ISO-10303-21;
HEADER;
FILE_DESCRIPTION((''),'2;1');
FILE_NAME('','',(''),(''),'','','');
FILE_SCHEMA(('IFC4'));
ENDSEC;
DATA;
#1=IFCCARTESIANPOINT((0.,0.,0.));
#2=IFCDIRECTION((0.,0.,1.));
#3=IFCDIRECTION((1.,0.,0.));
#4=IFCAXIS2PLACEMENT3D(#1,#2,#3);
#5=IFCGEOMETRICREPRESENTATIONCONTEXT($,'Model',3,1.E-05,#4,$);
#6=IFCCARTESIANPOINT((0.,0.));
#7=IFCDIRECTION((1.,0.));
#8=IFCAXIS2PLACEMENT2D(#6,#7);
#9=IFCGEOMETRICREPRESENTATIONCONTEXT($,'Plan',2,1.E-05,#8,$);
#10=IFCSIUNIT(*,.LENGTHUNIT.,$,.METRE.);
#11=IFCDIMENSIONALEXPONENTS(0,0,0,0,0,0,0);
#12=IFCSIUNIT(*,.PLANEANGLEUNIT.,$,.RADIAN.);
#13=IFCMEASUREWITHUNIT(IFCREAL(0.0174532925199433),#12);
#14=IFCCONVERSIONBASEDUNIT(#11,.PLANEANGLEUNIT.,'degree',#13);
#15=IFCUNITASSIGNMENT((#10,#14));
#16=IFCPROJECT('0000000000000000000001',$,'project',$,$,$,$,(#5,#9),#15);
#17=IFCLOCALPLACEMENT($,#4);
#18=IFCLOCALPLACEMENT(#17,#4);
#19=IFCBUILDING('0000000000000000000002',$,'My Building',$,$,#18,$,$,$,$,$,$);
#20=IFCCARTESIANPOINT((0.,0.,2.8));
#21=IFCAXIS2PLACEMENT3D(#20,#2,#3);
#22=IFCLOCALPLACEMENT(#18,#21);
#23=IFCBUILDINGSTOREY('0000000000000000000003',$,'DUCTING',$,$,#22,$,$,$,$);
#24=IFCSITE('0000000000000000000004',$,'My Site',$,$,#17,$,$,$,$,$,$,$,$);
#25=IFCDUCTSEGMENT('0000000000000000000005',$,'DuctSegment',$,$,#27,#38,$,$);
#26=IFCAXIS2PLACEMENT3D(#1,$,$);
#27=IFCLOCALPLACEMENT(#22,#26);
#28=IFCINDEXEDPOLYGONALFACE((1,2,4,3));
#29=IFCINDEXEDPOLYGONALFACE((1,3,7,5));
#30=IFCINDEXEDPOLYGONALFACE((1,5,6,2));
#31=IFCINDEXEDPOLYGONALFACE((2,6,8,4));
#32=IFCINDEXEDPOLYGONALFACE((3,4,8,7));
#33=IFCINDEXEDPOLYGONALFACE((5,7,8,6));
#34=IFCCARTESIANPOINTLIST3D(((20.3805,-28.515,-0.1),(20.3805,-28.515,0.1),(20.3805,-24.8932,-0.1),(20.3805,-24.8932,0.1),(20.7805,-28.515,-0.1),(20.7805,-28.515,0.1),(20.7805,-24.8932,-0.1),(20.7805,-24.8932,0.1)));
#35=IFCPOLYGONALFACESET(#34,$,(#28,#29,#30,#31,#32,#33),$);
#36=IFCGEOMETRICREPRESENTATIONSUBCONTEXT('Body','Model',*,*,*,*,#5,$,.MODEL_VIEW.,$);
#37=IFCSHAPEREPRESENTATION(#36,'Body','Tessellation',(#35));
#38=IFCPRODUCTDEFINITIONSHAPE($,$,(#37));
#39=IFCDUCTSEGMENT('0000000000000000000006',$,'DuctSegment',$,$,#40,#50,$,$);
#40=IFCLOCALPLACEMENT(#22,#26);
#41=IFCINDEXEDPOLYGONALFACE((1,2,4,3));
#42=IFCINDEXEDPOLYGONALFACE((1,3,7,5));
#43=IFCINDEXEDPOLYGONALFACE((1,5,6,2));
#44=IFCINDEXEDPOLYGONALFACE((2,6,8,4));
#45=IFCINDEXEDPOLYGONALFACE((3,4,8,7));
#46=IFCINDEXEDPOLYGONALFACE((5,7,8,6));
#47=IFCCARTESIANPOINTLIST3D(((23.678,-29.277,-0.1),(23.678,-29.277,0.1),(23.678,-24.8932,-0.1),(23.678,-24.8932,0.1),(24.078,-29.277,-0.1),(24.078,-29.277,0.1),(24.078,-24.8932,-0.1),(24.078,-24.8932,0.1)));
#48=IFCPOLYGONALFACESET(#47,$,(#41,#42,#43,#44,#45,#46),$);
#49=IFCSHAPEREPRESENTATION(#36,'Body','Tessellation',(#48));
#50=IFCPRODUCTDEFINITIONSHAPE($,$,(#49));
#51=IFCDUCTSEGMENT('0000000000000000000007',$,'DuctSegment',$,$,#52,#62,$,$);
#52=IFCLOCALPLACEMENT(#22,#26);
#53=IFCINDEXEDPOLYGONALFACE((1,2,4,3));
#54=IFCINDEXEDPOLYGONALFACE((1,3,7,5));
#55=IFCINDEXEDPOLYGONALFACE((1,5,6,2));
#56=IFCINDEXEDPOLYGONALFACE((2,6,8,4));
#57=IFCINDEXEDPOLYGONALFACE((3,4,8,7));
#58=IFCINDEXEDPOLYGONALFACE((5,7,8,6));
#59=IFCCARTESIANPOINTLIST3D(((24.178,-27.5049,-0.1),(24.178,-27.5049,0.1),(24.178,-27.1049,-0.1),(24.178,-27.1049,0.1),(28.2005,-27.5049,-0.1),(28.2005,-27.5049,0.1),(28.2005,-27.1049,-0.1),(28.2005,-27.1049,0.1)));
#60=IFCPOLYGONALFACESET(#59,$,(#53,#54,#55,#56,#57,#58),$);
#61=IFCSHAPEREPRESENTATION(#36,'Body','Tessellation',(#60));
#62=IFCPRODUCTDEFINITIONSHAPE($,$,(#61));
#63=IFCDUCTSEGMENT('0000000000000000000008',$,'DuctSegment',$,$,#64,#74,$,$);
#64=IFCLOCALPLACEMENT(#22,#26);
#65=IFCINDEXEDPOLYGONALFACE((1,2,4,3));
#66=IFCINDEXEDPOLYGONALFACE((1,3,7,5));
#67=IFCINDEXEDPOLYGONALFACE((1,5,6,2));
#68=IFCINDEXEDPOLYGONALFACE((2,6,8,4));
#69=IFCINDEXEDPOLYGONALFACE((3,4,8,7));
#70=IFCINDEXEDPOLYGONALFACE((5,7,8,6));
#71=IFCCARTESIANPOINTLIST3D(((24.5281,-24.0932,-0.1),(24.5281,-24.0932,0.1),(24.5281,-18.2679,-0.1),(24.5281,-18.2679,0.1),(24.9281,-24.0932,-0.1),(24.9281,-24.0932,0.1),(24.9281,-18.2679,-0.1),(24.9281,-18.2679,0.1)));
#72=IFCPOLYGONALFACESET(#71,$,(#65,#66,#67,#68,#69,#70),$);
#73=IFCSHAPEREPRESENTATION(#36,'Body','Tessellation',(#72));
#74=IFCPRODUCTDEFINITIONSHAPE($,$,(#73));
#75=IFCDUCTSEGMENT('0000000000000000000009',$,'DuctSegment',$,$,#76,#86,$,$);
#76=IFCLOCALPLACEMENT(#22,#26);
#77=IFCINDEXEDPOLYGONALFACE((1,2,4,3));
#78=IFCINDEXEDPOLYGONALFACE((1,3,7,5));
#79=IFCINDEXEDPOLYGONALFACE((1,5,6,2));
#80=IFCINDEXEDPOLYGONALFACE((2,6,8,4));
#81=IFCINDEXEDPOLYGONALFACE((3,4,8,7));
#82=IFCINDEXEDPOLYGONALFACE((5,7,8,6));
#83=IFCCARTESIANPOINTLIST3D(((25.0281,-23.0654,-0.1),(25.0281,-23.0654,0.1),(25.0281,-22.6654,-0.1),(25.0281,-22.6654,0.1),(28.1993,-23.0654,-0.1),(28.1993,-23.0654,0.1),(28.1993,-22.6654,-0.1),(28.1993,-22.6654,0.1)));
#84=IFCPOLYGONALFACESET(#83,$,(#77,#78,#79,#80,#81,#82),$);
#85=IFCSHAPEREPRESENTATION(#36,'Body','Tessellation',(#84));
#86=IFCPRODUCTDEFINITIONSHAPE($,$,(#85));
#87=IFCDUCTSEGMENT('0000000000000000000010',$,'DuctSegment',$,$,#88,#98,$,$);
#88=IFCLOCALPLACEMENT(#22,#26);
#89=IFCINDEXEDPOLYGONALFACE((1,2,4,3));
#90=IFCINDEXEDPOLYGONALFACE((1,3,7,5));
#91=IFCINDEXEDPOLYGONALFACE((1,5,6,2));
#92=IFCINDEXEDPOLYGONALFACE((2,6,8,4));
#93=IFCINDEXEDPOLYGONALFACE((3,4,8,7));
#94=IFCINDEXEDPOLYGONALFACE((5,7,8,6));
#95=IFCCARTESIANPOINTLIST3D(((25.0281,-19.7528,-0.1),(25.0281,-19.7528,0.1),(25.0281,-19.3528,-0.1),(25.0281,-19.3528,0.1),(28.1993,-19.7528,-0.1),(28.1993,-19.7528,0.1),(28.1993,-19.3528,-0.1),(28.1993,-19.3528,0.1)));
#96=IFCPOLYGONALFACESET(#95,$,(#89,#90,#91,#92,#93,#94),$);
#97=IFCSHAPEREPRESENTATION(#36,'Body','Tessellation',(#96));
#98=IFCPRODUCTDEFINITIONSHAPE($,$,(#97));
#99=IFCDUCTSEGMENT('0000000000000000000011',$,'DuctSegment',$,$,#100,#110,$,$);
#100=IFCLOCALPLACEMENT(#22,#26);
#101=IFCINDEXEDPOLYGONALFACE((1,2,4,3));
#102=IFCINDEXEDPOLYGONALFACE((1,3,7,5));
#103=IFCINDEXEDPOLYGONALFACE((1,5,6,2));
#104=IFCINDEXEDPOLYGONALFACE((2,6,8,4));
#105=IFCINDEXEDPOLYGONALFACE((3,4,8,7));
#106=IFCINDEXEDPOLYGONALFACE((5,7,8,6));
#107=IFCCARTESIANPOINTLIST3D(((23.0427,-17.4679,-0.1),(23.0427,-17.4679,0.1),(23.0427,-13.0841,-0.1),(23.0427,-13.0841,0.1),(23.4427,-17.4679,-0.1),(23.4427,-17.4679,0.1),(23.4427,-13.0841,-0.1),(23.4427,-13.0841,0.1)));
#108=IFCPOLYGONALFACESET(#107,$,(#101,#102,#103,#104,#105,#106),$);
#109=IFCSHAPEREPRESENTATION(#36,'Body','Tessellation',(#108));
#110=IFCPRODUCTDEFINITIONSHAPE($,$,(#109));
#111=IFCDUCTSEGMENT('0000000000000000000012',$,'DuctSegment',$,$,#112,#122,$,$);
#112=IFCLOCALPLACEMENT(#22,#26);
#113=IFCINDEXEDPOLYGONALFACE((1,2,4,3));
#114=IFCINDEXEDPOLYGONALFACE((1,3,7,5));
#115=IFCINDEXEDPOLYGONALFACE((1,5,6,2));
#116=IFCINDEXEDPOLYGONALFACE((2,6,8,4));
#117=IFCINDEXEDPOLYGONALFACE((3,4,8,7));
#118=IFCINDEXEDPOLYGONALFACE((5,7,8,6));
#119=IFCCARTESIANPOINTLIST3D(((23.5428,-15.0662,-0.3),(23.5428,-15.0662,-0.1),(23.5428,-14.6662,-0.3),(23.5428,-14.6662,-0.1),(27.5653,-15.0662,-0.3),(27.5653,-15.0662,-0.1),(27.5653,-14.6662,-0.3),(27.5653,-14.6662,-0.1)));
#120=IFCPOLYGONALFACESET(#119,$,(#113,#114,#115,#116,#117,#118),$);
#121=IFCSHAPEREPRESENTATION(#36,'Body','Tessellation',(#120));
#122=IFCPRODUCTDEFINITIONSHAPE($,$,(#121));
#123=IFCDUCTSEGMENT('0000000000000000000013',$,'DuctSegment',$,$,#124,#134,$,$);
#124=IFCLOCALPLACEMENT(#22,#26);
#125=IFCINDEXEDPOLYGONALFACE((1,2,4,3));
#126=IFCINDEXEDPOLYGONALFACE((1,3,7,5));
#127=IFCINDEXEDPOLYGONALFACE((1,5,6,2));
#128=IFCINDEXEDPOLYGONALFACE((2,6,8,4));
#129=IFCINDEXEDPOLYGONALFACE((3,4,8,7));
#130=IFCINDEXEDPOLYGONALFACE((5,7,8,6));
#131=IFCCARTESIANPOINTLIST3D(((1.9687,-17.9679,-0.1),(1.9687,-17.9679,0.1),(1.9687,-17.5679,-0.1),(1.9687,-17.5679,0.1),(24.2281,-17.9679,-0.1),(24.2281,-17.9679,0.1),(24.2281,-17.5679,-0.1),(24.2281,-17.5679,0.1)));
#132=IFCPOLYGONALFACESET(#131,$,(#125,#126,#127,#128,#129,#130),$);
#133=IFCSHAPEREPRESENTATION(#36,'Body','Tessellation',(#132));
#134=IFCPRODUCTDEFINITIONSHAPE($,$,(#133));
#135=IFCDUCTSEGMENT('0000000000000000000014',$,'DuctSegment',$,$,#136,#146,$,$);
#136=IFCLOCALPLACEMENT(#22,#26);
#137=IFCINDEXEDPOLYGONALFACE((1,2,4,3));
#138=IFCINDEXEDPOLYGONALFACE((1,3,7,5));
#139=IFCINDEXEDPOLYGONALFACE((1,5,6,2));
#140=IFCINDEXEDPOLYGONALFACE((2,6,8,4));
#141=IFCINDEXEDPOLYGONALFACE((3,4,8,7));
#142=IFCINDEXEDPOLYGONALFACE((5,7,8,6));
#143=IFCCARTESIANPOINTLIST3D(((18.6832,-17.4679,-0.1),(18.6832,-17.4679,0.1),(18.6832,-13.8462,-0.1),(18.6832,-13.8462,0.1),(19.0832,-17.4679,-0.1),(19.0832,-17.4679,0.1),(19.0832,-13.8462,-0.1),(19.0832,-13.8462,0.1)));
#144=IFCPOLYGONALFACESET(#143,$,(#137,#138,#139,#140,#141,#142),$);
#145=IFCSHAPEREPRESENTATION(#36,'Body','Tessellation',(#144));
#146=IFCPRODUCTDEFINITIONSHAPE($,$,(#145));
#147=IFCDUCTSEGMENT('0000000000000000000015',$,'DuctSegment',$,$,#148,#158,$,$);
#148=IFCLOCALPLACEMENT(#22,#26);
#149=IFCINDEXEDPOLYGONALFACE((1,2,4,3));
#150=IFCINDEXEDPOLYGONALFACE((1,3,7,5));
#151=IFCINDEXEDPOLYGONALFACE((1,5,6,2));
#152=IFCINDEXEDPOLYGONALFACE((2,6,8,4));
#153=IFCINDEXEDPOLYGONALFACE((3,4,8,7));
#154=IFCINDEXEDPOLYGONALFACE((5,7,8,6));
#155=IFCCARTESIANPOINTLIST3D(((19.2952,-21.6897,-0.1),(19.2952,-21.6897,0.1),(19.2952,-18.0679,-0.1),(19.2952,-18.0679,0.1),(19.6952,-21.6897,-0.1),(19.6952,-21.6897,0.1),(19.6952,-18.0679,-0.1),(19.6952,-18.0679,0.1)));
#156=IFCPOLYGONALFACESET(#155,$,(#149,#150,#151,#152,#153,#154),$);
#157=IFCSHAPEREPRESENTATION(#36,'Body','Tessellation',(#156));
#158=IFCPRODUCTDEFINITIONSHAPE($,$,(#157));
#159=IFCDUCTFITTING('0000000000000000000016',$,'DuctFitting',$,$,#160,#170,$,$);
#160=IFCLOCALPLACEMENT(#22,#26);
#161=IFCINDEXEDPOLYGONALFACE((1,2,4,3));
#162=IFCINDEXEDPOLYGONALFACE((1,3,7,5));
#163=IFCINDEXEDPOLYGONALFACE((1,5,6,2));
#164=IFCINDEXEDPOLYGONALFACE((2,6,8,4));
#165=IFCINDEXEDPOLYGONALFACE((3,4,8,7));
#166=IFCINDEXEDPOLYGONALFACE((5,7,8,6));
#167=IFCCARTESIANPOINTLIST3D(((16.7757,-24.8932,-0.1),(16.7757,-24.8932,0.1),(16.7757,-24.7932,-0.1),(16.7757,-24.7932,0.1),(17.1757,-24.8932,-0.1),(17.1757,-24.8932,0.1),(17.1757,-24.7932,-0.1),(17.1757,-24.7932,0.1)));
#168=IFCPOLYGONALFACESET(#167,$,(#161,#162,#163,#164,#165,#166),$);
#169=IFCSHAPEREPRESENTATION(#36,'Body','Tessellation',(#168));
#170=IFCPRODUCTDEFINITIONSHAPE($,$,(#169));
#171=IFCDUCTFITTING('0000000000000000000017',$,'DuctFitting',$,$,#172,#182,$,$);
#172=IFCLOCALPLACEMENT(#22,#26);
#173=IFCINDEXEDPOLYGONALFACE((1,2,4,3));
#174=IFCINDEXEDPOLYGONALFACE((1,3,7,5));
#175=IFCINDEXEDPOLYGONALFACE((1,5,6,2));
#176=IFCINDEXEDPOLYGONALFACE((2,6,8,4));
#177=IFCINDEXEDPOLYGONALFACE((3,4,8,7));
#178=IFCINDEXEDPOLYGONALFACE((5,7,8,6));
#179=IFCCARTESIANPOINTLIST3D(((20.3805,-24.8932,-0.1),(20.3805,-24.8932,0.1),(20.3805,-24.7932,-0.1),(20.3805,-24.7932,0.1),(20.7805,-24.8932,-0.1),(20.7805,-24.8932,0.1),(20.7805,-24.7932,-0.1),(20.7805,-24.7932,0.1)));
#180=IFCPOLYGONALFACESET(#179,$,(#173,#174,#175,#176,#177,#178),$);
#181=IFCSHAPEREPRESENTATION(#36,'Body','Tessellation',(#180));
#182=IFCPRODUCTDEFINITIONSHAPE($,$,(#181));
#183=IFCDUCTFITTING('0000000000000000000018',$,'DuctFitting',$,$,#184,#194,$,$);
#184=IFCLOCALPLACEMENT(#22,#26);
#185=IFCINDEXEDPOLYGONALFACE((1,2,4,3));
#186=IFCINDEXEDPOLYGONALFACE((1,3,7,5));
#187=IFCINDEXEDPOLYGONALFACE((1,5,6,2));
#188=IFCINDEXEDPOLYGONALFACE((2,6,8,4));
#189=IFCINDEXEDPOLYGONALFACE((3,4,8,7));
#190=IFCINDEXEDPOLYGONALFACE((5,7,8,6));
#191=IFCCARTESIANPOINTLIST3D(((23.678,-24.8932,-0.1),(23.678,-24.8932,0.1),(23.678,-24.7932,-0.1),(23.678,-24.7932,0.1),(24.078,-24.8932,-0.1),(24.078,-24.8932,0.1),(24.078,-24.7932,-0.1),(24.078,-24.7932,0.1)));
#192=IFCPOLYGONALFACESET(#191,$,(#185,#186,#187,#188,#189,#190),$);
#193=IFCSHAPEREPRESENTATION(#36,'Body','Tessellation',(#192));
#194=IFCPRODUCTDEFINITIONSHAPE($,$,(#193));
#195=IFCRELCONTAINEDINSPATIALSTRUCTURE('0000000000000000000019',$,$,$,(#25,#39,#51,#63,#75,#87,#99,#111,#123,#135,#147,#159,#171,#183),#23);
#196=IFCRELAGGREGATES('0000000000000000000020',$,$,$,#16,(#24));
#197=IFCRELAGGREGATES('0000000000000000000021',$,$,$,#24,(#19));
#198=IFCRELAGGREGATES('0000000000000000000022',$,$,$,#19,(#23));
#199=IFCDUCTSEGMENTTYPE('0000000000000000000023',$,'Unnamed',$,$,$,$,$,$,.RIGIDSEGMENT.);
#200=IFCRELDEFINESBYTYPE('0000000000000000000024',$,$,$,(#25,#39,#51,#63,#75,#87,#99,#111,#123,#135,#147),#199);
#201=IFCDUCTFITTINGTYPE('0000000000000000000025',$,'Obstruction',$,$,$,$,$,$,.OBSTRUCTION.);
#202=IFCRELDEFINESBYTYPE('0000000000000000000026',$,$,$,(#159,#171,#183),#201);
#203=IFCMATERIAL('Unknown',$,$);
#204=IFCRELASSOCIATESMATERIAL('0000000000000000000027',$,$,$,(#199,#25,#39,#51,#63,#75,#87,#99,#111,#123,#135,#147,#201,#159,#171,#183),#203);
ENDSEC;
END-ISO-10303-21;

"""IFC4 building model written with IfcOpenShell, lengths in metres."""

from ifc_helpers import new_model, entity, si_unit, converted_unit, frame, origin_with_axes, origin_2d_with_axis, place, context, subcontext, project, spatial, rectangle, extrude, material, material_profile, profile_set, profile_usage, type_object, element, save


model = new_model("IFC4")

# Units and contexts
model_context = context("Model", 3, precision=1e-05, world=origin_with_axes())
plan_context = context("Plan", 2, precision=1e-05, world=origin_2d_with_axis())
body_context = subcontext(model_context, "Body", "Model", "MODEL_VIEW")
ifc_project = project(units=[si_unit("LENGTHUNIT", "METRE"), converted_unit("PLANEANGLEUNIT", "degree", entity("IfcReal", 0.0174532925199433), si_unit("PLANEANGLEUNIT", "RADIAN"), dimensions=[0, 0, 0, 0, 0, 0, 0])], contexts=[model_context, plan_context])

# Site, building, storey
site_placement = place(None, origin_with_axes())
site = spatial("IfcSite", under=ifc_project, at=site_placement, Name="My Site")
building_placement = place(site_placement, origin_with_axes())
building = spatial("IfcBuilding", under=site, at=building_placement, Name="My Building")
storey_placement = place(building_placement, frame((0.0, 0.0, 2.8), z_axis=(0.0, 0.0, 1.0), x_axis=(1.0, 0.0, 0.0)))
storey = spatial("IfcBuildingStorey", under=building, at=storey_placement, Name="DUCTING")

# Duct segments
ifc_material = material(Name="Unknown")
ifc_material_profile_1 = material_profile(ifc_material, rectangle(XDim=0.4, YDim=0.2))
ifc_profile_set_1 = profile_set([ifc_material_profile_1])
ifc_profile_usage_1 = profile_usage(ifc_profile_set_1, cardinal=5)
duct_segment_type = type_object("IfcDuctSegmentType", Name="Unnamed", PredefinedType="RIGIDSEGMENT", material=ifc_profile_set_1)
duct_segment_1_placement = place(storey_placement, frame((20.5805, -28.515, 0.0), z_axis=(0.0, 1.0, 0.0), x_axis=(-1.0, 0.0, 0.0)))
element("IfcDuctSegment", 1, at=duct_segment_1_placement, inside=storey, type_object=duct_segment_type, material=ifc_profile_usage_1, Name="DuctSegment", context=body_context, shape_type="SweptSolid", body=[
    extrude(rectangle(XDim=0.4, YDim=0.2), origin_with_axes(), (0.0, 0.0, 1.0), 3.6218),
])
ifc_profile_usage_2 = profile_usage(ifc_profile_set_1, cardinal=5)
duct_segment_2_placement = place(storey_placement, frame((23.878, -29.277, 0.0), z_axis=(0.0, 1.0, 0.0), x_axis=(-1.0, 0.0, 0.0)))
element("IfcDuctSegment", 2, at=duct_segment_2_placement, inside=storey, type_object=duct_segment_type, material=ifc_profile_usage_2, Name="DuctSegment", context=body_context, shape_type="SweptSolid", body=[
    extrude(rectangle(XDim=0.4, YDim=0.2), origin_with_axes(), (0.0, 0.0, 1.0), 4.3838),
])
ifc_profile_usage_3 = profile_usage(ifc_profile_set_1, cardinal=5)
duct_segment_3_placement = place(storey_placement, frame((28.2005, -27.3049, 0.0), z_axis=(-1.0, 0.0, -0.000001), x_axis=(0.0, -1.0, 0.0)))
element("IfcDuctSegment", 3, at=duct_segment_3_placement, inside=storey, type_object=duct_segment_type, material=ifc_profile_usage_3, Name="DuctSegment", context=body_context, shape_type="SweptSolid", body=[
    extrude(rectangle(XDim=0.4, YDim=0.2), origin_with_axes(), (0.0, 0.0, 1.0), 4.0225),
])
ifc_profile_usage_4 = profile_usage(ifc_profile_set_1, cardinal=5)
duct_segment_4_placement = place(storey_placement, frame((24.7281, -24.0932, 0.0), z_axis=(0.0, 1.0, 0.0), x_axis=(-1.0, 0.0, 0.0)))
element("IfcDuctSegment", 4, at=duct_segment_4_placement, inside=storey, type_object=duct_segment_type, material=ifc_profile_usage_4, Name="DuctSegment", context=body_context, shape_type="SweptSolid", body=[
    extrude(rectangle(XDim=0.4, YDim=0.2), origin_with_axes(), (0.0, 0.0, 1.0), 5.8253),
])
ifc_profile_usage_5 = profile_usage(ifc_profile_set_1, cardinal=5)
duct_segment_5_placement = place(storey_placement, frame((28.1993, -22.8654, 0.0), z_axis=(-1.0, 0.0, -0.000001), x_axis=(0.0, -1.0, 0.0)))
element("IfcDuctSegment", 5, at=duct_segment_5_placement, inside=storey, type_object=duct_segment_type, material=ifc_profile_usage_5, Name="DuctSegment", context=body_context, shape_type="SweptSolid", body=[
    extrude(rectangle(XDim=0.4, YDim=0.2), origin_with_axes(), (0.0, 0.0, 1.0), 3.1712),
])
ifc_profile_usage_6 = profile_usage(ifc_profile_set_1, cardinal=5)
duct_segment_6_placement = place(storey_placement, frame((28.1993, -19.5528, 0.0), z_axis=(-1.0, 0.0, -0.000001), x_axis=(0.0, -1.0, 0.0)))
element("IfcDuctSegment", 6, at=duct_segment_6_placement, inside=storey, type_object=duct_segment_type, material=ifc_profile_usage_6, Name="DuctSegment", context=body_context, shape_type="SweptSolid", body=[
    extrude(rectangle(XDim=0.4, YDim=0.2), origin_with_axes(), (0.0, 0.0, 1.0), 3.1712),
])
ifc_profile_usage_7 = profile_usage(ifc_profile_set_1, cardinal=5)
duct_segment_7_placement = place(storey_placement, frame((23.2427, -13.0841, 0.0), z_axis=(0.0, -1.0, 0.0), x_axis=(1.0, 0.0, 0.0)))
element("IfcDuctSegment", 7, at=duct_segment_7_placement, inside=storey, type_object=duct_segment_type, material=ifc_profile_usage_7, Name="DuctSegment", context=body_context, shape_type="SweptSolid", body=[
    extrude(rectangle(XDim=0.4, YDim=0.2), origin_with_axes(), (0.0, 0.0, 1.0), 4.3838),
])
ifc_profile_usage_8 = profile_usage(ifc_profile_set_1, cardinal=5)
duct_segment_8_placement = place(storey_placement, frame((27.5653, -14.8662, -0.2), z_axis=(-1.0, 0.0, -0.000001), x_axis=(0.0, -1.0, 0.0)))
element("IfcDuctSegment", 8, at=duct_segment_8_placement, inside=storey, type_object=duct_segment_type, material=ifc_profile_usage_8, Name="DuctSegment", context=body_context, shape_type="SweptSolid", body=[
    extrude(rectangle(XDim=0.4, YDim=0.2), origin_with_axes(), (0.0, 0.0, 1.0), 4.0225),
])
ifc_profile_usage_9 = profile_usage(ifc_profile_set_1, cardinal=5)
duct_segment_9_placement = place(storey_placement, frame((24.2281, -17.7679, 0.0), z_axis=(-1.0, 0.0, 0.0), x_axis=(0.0, -1.0, 0.0)))
element("IfcDuctSegment", 9, at=duct_segment_9_placement, inside=storey, type_object=duct_segment_type, material=ifc_profile_usage_9, Name="DuctSegment", context=body_context, shape_type="SweptSolid", body=[
    extrude(rectangle(XDim=0.4, YDim=0.2), origin_with_axes(), (0.0, 0.0, 1.0), 22.2594),
])
ifc_profile_usage_10 = profile_usage(ifc_profile_set_1, cardinal=5)
duct_segment_10_placement = place(storey_placement, frame((18.8832, -13.8462, 0.0), z_axis=(0.0, -1.0, 0.0), x_axis=(1.0, 0.0, 0.0)))
element("IfcDuctSegment", 10, at=duct_segment_10_placement, inside=storey, type_object=duct_segment_type, material=ifc_profile_usage_10, Name="DuctSegment", context=body_context, shape_type="SweptSolid", body=[
    extrude(rectangle(XDim=0.4, YDim=0.2), origin_with_axes(), (0.0, 0.0, 1.0), 3.6218),
])
ifc_profile_usage_11 = profile_usage(ifc_profile_set_1, cardinal=5)
duct_segment_11_placement = place(storey_placement, frame((19.4952, -21.6897, 0.0), z_axis=(0.0, 1.0, 0.0), x_axis=(-1.0, 0.0, 0.0)))
element("IfcDuctSegment", 11, at=duct_segment_11_placement, inside=storey, type_object=duct_segment_type, material=ifc_profile_usage_11, Name="DuctSegment", context=body_context, shape_type="SweptSolid", body=[
    extrude(rectangle(XDim=0.4, YDim=0.2), origin_with_axes(), (0.0, 0.0, 1.0), 3.6218),
])

# Duct fittings
ifc_material_profile_2 = material_profile(ifc_material, rectangle(XDim=0.4, YDim=0.2))
ifc_profile_set_2 = profile_set([ifc_material_profile_2])
ifc_profile_usage_12 = profile_usage(ifc_profile_set_2, cardinal=5)
duct_fitting_type_1 = type_object("IfcDuctFittingType", Name="Obstruction", PredefinedType="OBSTRUCTION", material=ifc_profile_set_2)
duct_fitting_1_placement = place(storey_placement, frame((16.9757, -24.8932, 0.0), z_axis=(0.0, 1.0, 0.0), x_axis=(-1.0, 0.0, 0.0)))
element("IfcDuctFitting", 12, at=duct_fitting_1_placement, inside=storey, type_object=duct_fitting_type_1, material=ifc_profile_usage_12, Name="DuctFitting", context=body_context, shape_type="SweptSolid", body=[
    extrude(rectangle(XDim=0.4, YDim=0.2), origin_with_axes(), (0.0, 0.0, 1.0), 0.1),
])
ifc_profile_usage_13 = profile_usage(ifc_profile_set_2, cardinal=5)
duct_fitting_2_placement = place(storey_placement, frame((20.5805, -24.8932, 0.0), z_axis=(0.0, 1.0, 0.0), x_axis=(-1.0, 0.0, 0.0)))
element("IfcDuctFitting", 13, at=duct_fitting_2_placement, inside=storey, type_object=duct_fitting_type_1, material=ifc_profile_usage_13, Name="DuctFitting", context=body_context, shape_type="SweptSolid", body=[
    extrude(rectangle(XDim=0.4, YDim=0.2), origin_with_axes(), (0.0, 0.0, 1.0), 0.1),
])
ifc_profile_usage_14 = profile_usage(ifc_profile_set_2, cardinal=5)
duct_fitting_3_placement = place(storey_placement, frame((23.878, -24.8932, 0.0), z_axis=(0.0, 1.0, 0.0), x_axis=(-1.0, 0.0, 0.0)))
element("IfcDuctFitting", 14, at=duct_fitting_3_placement, inside=storey, type_object=duct_fitting_type_1, material=ifc_profile_usage_14, Name="DuctFitting", context=body_context, shape_type="SweptSolid", body=[
    extrude(rectangle(XDim=0.4, YDim=0.2), origin_with_axes(), (0.0, 0.0, 1.0), 0.1),
])

save(model, "model.ifc")
